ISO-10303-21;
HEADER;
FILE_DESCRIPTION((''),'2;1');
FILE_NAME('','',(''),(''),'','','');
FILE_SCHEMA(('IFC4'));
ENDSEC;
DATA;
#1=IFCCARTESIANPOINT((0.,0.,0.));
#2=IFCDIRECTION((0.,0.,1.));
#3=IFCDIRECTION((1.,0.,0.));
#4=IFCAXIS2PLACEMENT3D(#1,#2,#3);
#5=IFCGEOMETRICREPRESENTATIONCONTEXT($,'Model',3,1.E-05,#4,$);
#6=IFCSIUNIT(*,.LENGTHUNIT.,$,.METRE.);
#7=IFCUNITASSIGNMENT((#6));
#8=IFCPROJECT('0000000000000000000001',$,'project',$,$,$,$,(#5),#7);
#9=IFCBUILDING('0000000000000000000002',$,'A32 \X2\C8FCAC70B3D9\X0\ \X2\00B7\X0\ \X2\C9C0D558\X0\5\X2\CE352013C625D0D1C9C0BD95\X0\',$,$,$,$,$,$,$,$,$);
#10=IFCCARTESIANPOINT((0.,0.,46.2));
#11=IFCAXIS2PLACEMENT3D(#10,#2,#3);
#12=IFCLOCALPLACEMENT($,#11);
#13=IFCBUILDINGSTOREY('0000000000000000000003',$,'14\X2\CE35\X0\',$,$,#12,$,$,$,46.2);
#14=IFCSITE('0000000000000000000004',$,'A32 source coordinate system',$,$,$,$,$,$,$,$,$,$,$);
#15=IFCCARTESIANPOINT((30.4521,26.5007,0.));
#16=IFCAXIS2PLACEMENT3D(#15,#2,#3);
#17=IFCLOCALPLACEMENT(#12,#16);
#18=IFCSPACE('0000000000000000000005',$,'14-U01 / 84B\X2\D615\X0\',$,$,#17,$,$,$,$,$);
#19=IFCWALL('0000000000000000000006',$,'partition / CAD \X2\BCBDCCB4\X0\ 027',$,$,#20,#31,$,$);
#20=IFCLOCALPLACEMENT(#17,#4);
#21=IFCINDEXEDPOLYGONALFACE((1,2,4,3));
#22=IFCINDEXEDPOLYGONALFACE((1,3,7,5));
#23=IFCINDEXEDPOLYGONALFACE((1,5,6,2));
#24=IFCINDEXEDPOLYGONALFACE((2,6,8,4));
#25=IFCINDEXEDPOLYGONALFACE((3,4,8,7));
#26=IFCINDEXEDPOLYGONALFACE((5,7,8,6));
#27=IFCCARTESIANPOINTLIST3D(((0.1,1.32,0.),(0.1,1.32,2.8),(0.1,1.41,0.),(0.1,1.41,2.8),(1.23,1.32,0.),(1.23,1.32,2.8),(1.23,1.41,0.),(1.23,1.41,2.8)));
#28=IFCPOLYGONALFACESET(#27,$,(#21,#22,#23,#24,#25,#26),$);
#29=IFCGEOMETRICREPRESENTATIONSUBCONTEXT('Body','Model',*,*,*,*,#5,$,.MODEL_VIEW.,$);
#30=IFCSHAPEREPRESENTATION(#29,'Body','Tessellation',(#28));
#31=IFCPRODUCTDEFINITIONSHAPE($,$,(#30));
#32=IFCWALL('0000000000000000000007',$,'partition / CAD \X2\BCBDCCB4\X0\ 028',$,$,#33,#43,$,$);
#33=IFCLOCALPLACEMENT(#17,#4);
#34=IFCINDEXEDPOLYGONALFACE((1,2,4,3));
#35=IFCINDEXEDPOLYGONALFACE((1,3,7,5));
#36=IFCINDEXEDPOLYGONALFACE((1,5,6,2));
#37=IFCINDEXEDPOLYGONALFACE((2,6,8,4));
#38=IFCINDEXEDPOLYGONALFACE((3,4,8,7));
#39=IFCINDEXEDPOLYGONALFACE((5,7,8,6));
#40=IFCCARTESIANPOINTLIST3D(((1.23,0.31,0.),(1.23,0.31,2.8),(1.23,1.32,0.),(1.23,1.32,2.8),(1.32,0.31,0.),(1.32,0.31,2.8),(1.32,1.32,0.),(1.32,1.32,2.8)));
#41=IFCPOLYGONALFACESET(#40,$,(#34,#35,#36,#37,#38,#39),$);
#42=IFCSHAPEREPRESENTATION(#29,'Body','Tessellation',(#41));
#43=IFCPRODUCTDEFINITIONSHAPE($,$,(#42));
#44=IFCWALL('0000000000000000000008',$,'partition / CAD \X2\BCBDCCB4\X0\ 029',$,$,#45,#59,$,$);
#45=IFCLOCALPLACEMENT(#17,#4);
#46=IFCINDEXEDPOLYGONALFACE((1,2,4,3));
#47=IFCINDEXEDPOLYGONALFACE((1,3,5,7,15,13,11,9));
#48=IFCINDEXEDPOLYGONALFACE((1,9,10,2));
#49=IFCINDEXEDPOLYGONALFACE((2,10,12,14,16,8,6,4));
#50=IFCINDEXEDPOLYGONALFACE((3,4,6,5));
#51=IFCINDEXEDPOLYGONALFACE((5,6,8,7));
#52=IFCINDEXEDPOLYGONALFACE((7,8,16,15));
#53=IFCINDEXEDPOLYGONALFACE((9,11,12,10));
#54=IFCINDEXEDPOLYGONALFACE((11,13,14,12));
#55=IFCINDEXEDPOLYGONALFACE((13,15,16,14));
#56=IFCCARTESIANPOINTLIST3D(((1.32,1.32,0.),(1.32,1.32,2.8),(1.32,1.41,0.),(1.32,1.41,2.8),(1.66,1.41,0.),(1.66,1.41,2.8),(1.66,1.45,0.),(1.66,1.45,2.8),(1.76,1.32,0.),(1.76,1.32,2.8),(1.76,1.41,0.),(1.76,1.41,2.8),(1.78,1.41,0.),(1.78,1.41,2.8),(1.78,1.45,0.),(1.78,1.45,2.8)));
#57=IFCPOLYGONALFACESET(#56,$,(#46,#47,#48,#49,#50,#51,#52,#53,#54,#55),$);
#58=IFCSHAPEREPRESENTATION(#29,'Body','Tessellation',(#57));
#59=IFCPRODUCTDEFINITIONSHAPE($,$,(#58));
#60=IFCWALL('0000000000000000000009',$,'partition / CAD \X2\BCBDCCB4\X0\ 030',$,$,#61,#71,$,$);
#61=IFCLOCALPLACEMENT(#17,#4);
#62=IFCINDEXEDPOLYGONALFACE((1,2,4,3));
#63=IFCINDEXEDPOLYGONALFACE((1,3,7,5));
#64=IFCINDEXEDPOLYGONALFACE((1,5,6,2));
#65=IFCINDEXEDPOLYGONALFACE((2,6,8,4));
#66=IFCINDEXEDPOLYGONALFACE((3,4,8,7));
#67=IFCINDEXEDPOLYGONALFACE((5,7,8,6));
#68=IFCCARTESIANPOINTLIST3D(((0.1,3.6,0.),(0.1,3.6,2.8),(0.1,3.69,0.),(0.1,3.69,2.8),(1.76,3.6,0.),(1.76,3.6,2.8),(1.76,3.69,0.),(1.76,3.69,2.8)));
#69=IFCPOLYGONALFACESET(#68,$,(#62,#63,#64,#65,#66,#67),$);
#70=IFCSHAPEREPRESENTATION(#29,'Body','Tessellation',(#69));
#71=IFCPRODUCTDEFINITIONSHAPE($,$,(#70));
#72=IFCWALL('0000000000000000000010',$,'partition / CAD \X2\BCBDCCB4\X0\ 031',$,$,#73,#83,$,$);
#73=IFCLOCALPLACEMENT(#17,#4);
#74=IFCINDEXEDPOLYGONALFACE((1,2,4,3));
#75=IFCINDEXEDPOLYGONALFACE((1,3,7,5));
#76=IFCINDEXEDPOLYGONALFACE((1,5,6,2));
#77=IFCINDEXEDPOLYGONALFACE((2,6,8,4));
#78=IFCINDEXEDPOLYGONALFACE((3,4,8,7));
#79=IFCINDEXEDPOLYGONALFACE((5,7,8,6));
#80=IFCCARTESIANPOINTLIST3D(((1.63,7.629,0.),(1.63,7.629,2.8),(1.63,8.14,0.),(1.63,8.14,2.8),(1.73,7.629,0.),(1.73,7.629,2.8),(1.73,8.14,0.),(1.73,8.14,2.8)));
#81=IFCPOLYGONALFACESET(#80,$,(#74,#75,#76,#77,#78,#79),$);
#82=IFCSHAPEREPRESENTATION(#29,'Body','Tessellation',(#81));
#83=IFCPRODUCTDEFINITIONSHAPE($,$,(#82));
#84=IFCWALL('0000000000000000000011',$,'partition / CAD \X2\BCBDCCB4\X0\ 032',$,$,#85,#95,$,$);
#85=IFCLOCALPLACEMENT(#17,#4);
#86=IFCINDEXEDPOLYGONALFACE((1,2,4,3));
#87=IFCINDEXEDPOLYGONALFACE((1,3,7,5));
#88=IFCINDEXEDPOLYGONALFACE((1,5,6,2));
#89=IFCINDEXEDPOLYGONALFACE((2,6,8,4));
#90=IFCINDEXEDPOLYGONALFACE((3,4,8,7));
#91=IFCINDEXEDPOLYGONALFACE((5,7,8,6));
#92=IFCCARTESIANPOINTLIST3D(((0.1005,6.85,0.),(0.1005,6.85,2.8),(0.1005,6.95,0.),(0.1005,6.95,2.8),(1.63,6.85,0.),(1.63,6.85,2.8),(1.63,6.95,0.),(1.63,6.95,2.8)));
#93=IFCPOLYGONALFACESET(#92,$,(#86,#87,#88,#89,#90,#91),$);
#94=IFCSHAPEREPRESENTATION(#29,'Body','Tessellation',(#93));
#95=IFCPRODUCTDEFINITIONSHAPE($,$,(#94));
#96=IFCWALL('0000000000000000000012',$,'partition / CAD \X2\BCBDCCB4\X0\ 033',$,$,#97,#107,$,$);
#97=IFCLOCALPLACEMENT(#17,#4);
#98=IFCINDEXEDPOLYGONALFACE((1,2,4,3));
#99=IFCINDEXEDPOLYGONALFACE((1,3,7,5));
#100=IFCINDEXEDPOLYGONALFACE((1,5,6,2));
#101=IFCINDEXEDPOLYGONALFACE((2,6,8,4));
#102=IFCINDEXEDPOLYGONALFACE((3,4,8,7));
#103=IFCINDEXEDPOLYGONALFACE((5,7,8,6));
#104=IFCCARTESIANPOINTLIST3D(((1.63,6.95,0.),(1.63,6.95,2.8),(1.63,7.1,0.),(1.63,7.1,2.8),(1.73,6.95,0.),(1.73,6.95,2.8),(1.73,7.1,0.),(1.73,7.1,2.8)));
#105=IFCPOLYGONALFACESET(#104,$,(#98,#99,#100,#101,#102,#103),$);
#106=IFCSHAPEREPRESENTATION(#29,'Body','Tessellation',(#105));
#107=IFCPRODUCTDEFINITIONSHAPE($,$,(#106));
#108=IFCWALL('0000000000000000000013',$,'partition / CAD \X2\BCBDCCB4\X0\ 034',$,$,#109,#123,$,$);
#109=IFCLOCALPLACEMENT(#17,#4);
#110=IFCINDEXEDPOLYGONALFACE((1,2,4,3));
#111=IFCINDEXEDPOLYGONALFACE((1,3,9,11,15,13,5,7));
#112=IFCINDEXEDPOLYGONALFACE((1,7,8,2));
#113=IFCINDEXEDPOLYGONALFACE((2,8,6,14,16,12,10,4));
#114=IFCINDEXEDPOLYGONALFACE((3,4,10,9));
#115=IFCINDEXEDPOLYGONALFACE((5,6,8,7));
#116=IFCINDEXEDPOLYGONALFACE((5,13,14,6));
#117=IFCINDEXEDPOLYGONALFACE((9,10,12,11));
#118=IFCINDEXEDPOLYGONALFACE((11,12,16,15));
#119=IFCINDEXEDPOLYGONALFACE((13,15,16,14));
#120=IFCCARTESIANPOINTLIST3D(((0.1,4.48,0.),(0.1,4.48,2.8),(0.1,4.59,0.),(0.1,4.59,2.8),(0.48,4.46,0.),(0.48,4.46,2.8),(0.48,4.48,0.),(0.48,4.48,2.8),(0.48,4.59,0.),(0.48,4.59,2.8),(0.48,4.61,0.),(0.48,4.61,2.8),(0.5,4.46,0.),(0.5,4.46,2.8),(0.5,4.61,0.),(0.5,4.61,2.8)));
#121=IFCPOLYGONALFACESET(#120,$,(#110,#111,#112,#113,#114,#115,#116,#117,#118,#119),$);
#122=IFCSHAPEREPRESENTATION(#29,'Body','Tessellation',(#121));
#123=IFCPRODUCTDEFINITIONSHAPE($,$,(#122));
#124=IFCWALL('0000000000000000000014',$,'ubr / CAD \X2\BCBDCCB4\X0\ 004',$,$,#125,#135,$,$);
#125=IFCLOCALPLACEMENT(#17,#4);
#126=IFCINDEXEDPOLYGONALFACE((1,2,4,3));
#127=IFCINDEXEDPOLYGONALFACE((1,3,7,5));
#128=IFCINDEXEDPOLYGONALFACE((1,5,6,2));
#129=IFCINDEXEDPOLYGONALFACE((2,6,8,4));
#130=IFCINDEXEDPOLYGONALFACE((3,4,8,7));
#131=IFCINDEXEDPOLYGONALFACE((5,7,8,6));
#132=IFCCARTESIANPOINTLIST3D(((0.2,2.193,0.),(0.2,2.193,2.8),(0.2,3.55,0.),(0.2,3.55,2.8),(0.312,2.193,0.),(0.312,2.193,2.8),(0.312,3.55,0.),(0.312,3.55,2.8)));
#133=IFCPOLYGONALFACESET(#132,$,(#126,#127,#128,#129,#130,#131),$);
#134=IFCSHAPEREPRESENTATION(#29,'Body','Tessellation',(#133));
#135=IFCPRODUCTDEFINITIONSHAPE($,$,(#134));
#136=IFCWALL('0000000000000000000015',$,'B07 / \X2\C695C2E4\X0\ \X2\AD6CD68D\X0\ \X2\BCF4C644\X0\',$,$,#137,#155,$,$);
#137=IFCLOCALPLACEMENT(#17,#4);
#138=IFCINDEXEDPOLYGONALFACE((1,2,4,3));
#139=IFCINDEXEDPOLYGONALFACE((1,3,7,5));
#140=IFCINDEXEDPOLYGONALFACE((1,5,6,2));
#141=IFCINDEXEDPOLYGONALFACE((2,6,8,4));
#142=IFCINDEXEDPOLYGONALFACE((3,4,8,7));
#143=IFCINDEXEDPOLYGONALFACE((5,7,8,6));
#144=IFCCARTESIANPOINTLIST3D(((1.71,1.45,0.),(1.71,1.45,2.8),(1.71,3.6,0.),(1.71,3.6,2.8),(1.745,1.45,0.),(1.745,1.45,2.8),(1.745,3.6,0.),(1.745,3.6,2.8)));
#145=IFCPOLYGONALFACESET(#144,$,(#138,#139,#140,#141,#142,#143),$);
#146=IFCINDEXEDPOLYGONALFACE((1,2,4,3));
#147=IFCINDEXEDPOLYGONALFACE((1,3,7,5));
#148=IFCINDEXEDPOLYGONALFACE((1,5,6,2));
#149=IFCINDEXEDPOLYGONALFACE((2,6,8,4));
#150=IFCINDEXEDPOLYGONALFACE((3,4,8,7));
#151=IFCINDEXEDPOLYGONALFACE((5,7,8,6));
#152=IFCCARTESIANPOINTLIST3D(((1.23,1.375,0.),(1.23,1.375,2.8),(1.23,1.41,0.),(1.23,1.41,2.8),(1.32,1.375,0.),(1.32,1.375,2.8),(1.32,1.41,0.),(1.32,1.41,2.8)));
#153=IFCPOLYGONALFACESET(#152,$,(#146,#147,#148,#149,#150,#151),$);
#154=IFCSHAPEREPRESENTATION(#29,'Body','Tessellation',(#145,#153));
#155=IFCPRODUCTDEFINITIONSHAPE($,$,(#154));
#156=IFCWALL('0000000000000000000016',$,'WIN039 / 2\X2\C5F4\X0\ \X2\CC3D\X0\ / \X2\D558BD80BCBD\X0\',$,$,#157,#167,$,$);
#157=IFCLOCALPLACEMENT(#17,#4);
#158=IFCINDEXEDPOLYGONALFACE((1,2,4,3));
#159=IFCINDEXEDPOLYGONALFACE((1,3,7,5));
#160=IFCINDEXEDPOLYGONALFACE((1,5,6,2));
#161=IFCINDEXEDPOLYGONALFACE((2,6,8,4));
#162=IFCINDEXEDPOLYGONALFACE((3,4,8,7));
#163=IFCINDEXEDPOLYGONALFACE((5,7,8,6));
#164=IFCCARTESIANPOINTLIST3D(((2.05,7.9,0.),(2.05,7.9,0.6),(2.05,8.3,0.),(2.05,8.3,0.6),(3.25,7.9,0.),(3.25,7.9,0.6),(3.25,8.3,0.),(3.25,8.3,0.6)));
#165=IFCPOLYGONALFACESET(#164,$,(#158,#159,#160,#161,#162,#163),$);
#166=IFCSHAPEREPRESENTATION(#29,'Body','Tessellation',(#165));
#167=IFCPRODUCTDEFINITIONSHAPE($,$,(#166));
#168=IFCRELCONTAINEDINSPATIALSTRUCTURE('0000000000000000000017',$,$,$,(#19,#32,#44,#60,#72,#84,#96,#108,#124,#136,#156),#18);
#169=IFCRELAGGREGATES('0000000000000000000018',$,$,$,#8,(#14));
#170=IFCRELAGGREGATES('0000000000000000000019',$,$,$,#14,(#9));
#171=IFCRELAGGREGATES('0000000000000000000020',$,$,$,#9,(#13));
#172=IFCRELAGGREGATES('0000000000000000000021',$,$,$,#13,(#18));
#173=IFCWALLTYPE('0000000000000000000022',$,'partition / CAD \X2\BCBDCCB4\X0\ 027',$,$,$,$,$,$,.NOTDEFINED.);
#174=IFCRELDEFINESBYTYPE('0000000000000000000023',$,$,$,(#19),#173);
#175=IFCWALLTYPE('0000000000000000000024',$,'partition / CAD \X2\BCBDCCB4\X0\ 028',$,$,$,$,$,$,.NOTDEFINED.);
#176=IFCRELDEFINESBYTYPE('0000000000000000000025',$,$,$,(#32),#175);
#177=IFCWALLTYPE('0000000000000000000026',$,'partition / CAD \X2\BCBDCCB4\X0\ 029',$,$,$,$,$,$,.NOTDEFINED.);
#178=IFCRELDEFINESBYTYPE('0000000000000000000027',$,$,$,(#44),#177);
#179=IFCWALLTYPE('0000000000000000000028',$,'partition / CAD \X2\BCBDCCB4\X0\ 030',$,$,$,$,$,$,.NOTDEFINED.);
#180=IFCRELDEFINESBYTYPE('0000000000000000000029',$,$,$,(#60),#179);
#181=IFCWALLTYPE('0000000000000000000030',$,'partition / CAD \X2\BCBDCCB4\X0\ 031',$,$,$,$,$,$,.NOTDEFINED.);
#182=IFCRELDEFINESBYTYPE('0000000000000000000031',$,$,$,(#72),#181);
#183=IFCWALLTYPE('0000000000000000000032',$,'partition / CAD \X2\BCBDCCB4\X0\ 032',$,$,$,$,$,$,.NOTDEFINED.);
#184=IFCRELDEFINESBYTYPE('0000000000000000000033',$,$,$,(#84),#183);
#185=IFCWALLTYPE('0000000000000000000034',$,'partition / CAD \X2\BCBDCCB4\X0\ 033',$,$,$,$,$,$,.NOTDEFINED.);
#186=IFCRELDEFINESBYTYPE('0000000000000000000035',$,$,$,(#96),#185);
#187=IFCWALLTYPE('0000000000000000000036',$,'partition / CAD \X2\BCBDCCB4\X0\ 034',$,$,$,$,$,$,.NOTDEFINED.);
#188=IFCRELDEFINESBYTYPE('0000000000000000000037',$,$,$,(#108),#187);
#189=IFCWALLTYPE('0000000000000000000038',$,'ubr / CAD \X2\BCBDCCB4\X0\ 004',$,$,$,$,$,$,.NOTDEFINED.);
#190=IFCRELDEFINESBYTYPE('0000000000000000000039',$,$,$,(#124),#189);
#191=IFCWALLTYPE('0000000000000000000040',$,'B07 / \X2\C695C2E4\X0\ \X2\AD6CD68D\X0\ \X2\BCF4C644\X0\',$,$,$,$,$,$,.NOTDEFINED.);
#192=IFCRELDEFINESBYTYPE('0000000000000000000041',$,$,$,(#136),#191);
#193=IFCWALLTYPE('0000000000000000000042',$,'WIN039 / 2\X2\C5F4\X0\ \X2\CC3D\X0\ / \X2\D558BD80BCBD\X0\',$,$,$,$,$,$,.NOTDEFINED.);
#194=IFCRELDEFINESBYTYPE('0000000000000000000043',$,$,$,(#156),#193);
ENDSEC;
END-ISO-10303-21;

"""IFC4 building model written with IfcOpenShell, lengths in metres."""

from ifc_helpers import new_model, si_unit, frame, origin, origin_with_axes, place, context, subcontext, project, spatial, polyline, outline, extrude, source, transform, mapped, type_object, type_shapes, element, save


model = new_model("IFC4")

# Units and contexts
model_context = context("Model", 3, precision=1e-05, world=origin_with_axes())
body_context = subcontext(model_context, "Body", "Model", "MODEL_VIEW")
ifc_project = project(units=[si_unit("LENGTHUNIT", "METRE")], contexts=[model_context])

# Site, building, storey, space
site = spatial("IfcSite", under=ifc_project, Name="A32 source coordinate system")
building = spatial("IfcBuilding", under=site, Name="A32 주거동 · 지하5층–옥탑지붕")
storey_placement = place(None, frame((0.0, 0.0, 46.2), z_axis=(0.0, 0.0, 1.0), x_axis=(1.0, 0.0, 0.0)))
storey = spatial("IfcBuildingStorey", under=building, at=storey_placement, Name="14층", Elevation=46.2)
space_placement = place(storey_placement, frame((30.4521, 26.5007, 0.0), z_axis=(0.0, 0.0, 1.0), x_axis=(1.0, 0.0, 0.0)))
space = spatial("IfcSpace", under=storey, at=space_placement, Name="14-U01 / 84B형")

# Walls
wall_type_1 = type_object("IfcWallType", Name="partition / CAD 벽체 027", PredefinedType="NOTDEFINED")
shared_shape_1 = source(origin(), body_context, "Body", "SweptSolid", [
    extrude(outline(polyline([(0.1, 1.32), (0.1, 1.41), (1.23, 1.41), (1.23, 1.32), (0.1, 1.32)])), origin(), (0.0, 0.0, 1.0), 2.8),
])
type_shapes(wall_type_1, [shared_shape_1])
wall_1_placement = place(space_placement, origin_with_axes())
element("IfcWall", 1, at=wall_1_placement, inside=space, type_object=wall_type_1, Name="partition / CAD 벽체 027", context=body_context, shape_type="MappedRepresentation", body=[
    mapped(shared_shape_1, transform((0.0, 0.0, 0.0), scale=1.0)),
])
wall_type_2 = type_object("IfcWallType", Name="partition / CAD 벽체 028", PredefinedType="NOTDEFINED")
shared_shape_2 = source(origin(), body_context, "Body", "SweptSolid", [
    extrude(outline(polyline([(1.32, 0.31), (1.23, 0.31), (1.23, 1.32), (1.32, 1.32), (1.32, 0.31)])), origin(), (0.0, 0.0, 1.0), 2.8),
])
type_shapes(wall_type_2, [shared_shape_2])
wall_2_placement = place(space_placement, origin_with_axes())
element("IfcWall", 2, at=wall_2_placement, inside=space, type_object=wall_type_2, Name="partition / CAD 벽체 028", context=body_context, shape_type="MappedRepresentation", body=[
    mapped(shared_shape_2, transform((0.0, 0.0, 0.0), scale=1.0)),
])
wall_type_3 = type_object("IfcWallType", Name="partition / CAD 벽체 029", PredefinedType="NOTDEFINED")
shared_shape_3 = source(origin(), body_context, "Body", "SweptSolid", [
    extrude(outline(polyline([(1.66, 1.41), (1.66, 1.45), (1.78, 1.45), (1.78, 1.41), (1.76, 1.41), (1.76, 1.32), (1.32, 1.32), (1.32, 1.41), (1.66, 1.41)])), origin(), (0.0, 0.0, 1.0), 2.8),
])
type_shapes(wall_type_3, [shared_shape_3])
wall_3_placement = place(space_placement, origin_with_axes())
element("IfcWall", 3, at=wall_3_placement, inside=space, type_object=wall_type_3, Name="partition / CAD 벽체 029", context=body_context, shape_type="MappedRepresentation", body=[
    mapped(shared_shape_3, transform((0.0, 0.0, 0.0), scale=1.0)),
])
wall_type_4 = type_object("IfcWallType", Name="partition / CAD 벽체 030", PredefinedType="NOTDEFINED")
shared_shape_4 = source(origin(), body_context, "Body", "SweptSolid", [
    extrude(outline(polyline([(1.76, 3.69), (1.76, 3.6), (0.1, 3.6), (0.1, 3.69), (1.76, 3.69)])), origin(), (0.0, 0.0, 1.0), 2.8),
])
type_shapes(wall_type_4, [shared_shape_4])
wall_4_placement = place(space_placement, origin_with_axes())
element("IfcWall", 4, at=wall_4_placement, inside=space, type_object=wall_type_4, Name="partition / CAD 벽체 030", context=body_context, shape_type="MappedRepresentation", body=[
    mapped(shared_shape_4, transform((0.0, 0.0, 0.0), scale=1.0)),
])
wall_type_5 = type_object("IfcWallType", Name="partition / CAD 벽체 031", PredefinedType="NOTDEFINED")
shared_shape_5 = source(origin(), body_context, "Body", "SweptSolid", [
    extrude(outline(polyline([(1.63, 8.14), (1.73, 8.14), (1.73, 7.629), (1.63, 7.629), (1.63, 8.14)])), origin(), (0.0, 0.0, 1.0), 2.8),
])
type_shapes(wall_type_5, [shared_shape_5])
wall_5_placement = place(space_placement, origin_with_axes())
element("IfcWall", 5, at=wall_5_placement, inside=space, type_object=wall_type_5, Name="partition / CAD 벽체 031", context=body_context, shape_type="MappedRepresentation", body=[
    mapped(shared_shape_5, transform((0.0, 0.0, 0.0), scale=1.0)),
])
wall_type_6 = type_object("IfcWallType", Name="partition / CAD 벽체 032", PredefinedType="NOTDEFINED")
shared_shape_6 = source(origin(), body_context, "Body", "SweptSolid", [
    extrude(outline(polyline([(0.1005, 6.95), (1.63, 6.95), (1.63, 6.85), (0.1005, 6.85), (0.1005, 6.95)])), origin(), (0.0, 0.0, 1.0), 2.8),
])
type_shapes(wall_type_6, [shared_shape_6])
wall_6_placement = place(space_placement, origin_with_axes())
element("IfcWall", 6, at=wall_6_placement, inside=space, type_object=wall_type_6, Name="partition / CAD 벽체 032", context=body_context, shape_type="MappedRepresentation", body=[
    mapped(shared_shape_6, transform((0.0, 0.0, 0.0), scale=1.0)),
])
wall_type_7 = type_object("IfcWallType", Name="partition / CAD 벽체 033", PredefinedType="NOTDEFINED")
shared_shape_7 = source(origin(), body_context, "Body", "SweptSolid", [
    extrude(outline(polyline([(1.63, 7.1), (1.73, 7.1), (1.73, 6.95), (1.63, 6.95), (1.63, 7.1)])), origin(), (0.0, 0.0, 1.0), 2.8),
])
type_shapes(wall_type_7, [shared_shape_7])
wall_7_placement = place(space_placement, origin_with_axes())
element("IfcWall", 7, at=wall_7_placement, inside=space, type_object=wall_type_7, Name="partition / CAD 벽체 033", context=body_context, shape_type="MappedRepresentation", body=[
    mapped(shared_shape_7, transform((0.0, 0.0, 0.0), scale=1.0)),
])
wall_type_8 = type_object("IfcWallType", Name="partition / CAD 벽체 034", PredefinedType="NOTDEFINED")
shared_shape_8 = source(origin(), body_context, "Body", "SweptSolid", [
    extrude(outline(polyline([(0.48, 4.61), (0.5, 4.61), (0.5, 4.46), (0.48, 4.46), (0.48, 4.48), (0.1, 4.48), (0.1, 4.59), (0.48, 4.59), (0.48, 4.61)])), origin(), (0.0, 0.0, 1.0), 2.8),
])
type_shapes(wall_type_8, [shared_shape_8])
wall_8_placement = place(space_placement, origin_with_axes())
element("IfcWall", 8, at=wall_8_placement, inside=space, type_object=wall_type_8, Name="partition / CAD 벽체 034", context=body_context, shape_type="MappedRepresentation", body=[
    mapped(shared_shape_8, transform((0.0, 0.0, 0.0), scale=1.0)),
])
wall_type_9 = type_object("IfcWallType", Name="ubr / CAD 벽체 004", PredefinedType="NOTDEFINED")
shared_shape_9 = source(origin(), body_context, "Body", "SweptSolid", [
    extrude(outline(polyline([(0.312, 2.193), (0.2, 2.193), (0.2, 3.55), (0.312, 3.55), (0.312, 2.193)])), origin(), (0.0, 0.0, 1.0), 2.8),
])
type_shapes(wall_type_9, [shared_shape_9])
wall_9_placement = place(space_placement, origin_with_axes())
element("IfcWall", 9, at=wall_9_placement, inside=space, type_object=wall_type_9, Name="ubr / CAD 벽체 004", context=body_context, shape_type="MappedRepresentation", body=[
    mapped(shared_shape_9, transform((0.0, 0.0, 0.0), scale=1.0)),
])
wall_type_10 = type_object("IfcWallType", Name="B07 / 욕실 구획 보완", PredefinedType="NOTDEFINED")
shared_shape_10 = source(origin(), body_context, "Body", "SweptSolid", [
    extrude(outline(polyline([(1.71, 1.45), (1.71, 3.6), (1.745, 3.6), (1.745, 1.45), (1.71, 1.45)])), origin(), (0.0, 0.0, 1.0), 2.8),
    extrude(outline(polyline([(1.32, 1.41), (1.32, 1.375), (1.23, 1.375), (1.23, 1.41), (1.32, 1.41)])), origin(), (0.0, 0.0, 1.0), 2.8),
])
type_shapes(wall_type_10, [shared_shape_10])
wall_10_placement = place(space_placement, origin_with_axes())
element("IfcWall", 10, at=wall_10_placement, inside=space, type_object=wall_type_10, Name="B07 / 욕실 구획 보완", context=body_context, shape_type="MappedRepresentation", body=[
    mapped(shared_shape_10, transform((0.0, 0.0, 0.0), scale=1.0)),
])
wall_type_11 = type_object("IfcWallType", Name="WIN039 / 2열 창 / 하부벽", PredefinedType="NOTDEFINED")
shared_shape_11 = source(origin(), body_context, "Body", "SweptSolid", [
    extrude(outline(polyline([(2.05, 8.3), (3.25, 8.3), (3.25, 7.9), (2.05, 7.9), (2.05, 8.3)])), origin(), (0.0, 0.0, 1.0), 0.6),
])
type_shapes(wall_type_11, [shared_shape_11])
wall_11_placement = place(space_placement, origin_with_axes())
element("IfcWall", 11, at=wall_11_placement, inside=space, type_object=wall_type_11, Name="WIN039 / 2열 창 / 하부벽", context=body_context, shape_type="MappedRepresentation", body=[
    mapped(shared_shape_11, transform((0.0, 0.0, 0.0), scale=1.0)),
])

save(model, "model.ifc")
